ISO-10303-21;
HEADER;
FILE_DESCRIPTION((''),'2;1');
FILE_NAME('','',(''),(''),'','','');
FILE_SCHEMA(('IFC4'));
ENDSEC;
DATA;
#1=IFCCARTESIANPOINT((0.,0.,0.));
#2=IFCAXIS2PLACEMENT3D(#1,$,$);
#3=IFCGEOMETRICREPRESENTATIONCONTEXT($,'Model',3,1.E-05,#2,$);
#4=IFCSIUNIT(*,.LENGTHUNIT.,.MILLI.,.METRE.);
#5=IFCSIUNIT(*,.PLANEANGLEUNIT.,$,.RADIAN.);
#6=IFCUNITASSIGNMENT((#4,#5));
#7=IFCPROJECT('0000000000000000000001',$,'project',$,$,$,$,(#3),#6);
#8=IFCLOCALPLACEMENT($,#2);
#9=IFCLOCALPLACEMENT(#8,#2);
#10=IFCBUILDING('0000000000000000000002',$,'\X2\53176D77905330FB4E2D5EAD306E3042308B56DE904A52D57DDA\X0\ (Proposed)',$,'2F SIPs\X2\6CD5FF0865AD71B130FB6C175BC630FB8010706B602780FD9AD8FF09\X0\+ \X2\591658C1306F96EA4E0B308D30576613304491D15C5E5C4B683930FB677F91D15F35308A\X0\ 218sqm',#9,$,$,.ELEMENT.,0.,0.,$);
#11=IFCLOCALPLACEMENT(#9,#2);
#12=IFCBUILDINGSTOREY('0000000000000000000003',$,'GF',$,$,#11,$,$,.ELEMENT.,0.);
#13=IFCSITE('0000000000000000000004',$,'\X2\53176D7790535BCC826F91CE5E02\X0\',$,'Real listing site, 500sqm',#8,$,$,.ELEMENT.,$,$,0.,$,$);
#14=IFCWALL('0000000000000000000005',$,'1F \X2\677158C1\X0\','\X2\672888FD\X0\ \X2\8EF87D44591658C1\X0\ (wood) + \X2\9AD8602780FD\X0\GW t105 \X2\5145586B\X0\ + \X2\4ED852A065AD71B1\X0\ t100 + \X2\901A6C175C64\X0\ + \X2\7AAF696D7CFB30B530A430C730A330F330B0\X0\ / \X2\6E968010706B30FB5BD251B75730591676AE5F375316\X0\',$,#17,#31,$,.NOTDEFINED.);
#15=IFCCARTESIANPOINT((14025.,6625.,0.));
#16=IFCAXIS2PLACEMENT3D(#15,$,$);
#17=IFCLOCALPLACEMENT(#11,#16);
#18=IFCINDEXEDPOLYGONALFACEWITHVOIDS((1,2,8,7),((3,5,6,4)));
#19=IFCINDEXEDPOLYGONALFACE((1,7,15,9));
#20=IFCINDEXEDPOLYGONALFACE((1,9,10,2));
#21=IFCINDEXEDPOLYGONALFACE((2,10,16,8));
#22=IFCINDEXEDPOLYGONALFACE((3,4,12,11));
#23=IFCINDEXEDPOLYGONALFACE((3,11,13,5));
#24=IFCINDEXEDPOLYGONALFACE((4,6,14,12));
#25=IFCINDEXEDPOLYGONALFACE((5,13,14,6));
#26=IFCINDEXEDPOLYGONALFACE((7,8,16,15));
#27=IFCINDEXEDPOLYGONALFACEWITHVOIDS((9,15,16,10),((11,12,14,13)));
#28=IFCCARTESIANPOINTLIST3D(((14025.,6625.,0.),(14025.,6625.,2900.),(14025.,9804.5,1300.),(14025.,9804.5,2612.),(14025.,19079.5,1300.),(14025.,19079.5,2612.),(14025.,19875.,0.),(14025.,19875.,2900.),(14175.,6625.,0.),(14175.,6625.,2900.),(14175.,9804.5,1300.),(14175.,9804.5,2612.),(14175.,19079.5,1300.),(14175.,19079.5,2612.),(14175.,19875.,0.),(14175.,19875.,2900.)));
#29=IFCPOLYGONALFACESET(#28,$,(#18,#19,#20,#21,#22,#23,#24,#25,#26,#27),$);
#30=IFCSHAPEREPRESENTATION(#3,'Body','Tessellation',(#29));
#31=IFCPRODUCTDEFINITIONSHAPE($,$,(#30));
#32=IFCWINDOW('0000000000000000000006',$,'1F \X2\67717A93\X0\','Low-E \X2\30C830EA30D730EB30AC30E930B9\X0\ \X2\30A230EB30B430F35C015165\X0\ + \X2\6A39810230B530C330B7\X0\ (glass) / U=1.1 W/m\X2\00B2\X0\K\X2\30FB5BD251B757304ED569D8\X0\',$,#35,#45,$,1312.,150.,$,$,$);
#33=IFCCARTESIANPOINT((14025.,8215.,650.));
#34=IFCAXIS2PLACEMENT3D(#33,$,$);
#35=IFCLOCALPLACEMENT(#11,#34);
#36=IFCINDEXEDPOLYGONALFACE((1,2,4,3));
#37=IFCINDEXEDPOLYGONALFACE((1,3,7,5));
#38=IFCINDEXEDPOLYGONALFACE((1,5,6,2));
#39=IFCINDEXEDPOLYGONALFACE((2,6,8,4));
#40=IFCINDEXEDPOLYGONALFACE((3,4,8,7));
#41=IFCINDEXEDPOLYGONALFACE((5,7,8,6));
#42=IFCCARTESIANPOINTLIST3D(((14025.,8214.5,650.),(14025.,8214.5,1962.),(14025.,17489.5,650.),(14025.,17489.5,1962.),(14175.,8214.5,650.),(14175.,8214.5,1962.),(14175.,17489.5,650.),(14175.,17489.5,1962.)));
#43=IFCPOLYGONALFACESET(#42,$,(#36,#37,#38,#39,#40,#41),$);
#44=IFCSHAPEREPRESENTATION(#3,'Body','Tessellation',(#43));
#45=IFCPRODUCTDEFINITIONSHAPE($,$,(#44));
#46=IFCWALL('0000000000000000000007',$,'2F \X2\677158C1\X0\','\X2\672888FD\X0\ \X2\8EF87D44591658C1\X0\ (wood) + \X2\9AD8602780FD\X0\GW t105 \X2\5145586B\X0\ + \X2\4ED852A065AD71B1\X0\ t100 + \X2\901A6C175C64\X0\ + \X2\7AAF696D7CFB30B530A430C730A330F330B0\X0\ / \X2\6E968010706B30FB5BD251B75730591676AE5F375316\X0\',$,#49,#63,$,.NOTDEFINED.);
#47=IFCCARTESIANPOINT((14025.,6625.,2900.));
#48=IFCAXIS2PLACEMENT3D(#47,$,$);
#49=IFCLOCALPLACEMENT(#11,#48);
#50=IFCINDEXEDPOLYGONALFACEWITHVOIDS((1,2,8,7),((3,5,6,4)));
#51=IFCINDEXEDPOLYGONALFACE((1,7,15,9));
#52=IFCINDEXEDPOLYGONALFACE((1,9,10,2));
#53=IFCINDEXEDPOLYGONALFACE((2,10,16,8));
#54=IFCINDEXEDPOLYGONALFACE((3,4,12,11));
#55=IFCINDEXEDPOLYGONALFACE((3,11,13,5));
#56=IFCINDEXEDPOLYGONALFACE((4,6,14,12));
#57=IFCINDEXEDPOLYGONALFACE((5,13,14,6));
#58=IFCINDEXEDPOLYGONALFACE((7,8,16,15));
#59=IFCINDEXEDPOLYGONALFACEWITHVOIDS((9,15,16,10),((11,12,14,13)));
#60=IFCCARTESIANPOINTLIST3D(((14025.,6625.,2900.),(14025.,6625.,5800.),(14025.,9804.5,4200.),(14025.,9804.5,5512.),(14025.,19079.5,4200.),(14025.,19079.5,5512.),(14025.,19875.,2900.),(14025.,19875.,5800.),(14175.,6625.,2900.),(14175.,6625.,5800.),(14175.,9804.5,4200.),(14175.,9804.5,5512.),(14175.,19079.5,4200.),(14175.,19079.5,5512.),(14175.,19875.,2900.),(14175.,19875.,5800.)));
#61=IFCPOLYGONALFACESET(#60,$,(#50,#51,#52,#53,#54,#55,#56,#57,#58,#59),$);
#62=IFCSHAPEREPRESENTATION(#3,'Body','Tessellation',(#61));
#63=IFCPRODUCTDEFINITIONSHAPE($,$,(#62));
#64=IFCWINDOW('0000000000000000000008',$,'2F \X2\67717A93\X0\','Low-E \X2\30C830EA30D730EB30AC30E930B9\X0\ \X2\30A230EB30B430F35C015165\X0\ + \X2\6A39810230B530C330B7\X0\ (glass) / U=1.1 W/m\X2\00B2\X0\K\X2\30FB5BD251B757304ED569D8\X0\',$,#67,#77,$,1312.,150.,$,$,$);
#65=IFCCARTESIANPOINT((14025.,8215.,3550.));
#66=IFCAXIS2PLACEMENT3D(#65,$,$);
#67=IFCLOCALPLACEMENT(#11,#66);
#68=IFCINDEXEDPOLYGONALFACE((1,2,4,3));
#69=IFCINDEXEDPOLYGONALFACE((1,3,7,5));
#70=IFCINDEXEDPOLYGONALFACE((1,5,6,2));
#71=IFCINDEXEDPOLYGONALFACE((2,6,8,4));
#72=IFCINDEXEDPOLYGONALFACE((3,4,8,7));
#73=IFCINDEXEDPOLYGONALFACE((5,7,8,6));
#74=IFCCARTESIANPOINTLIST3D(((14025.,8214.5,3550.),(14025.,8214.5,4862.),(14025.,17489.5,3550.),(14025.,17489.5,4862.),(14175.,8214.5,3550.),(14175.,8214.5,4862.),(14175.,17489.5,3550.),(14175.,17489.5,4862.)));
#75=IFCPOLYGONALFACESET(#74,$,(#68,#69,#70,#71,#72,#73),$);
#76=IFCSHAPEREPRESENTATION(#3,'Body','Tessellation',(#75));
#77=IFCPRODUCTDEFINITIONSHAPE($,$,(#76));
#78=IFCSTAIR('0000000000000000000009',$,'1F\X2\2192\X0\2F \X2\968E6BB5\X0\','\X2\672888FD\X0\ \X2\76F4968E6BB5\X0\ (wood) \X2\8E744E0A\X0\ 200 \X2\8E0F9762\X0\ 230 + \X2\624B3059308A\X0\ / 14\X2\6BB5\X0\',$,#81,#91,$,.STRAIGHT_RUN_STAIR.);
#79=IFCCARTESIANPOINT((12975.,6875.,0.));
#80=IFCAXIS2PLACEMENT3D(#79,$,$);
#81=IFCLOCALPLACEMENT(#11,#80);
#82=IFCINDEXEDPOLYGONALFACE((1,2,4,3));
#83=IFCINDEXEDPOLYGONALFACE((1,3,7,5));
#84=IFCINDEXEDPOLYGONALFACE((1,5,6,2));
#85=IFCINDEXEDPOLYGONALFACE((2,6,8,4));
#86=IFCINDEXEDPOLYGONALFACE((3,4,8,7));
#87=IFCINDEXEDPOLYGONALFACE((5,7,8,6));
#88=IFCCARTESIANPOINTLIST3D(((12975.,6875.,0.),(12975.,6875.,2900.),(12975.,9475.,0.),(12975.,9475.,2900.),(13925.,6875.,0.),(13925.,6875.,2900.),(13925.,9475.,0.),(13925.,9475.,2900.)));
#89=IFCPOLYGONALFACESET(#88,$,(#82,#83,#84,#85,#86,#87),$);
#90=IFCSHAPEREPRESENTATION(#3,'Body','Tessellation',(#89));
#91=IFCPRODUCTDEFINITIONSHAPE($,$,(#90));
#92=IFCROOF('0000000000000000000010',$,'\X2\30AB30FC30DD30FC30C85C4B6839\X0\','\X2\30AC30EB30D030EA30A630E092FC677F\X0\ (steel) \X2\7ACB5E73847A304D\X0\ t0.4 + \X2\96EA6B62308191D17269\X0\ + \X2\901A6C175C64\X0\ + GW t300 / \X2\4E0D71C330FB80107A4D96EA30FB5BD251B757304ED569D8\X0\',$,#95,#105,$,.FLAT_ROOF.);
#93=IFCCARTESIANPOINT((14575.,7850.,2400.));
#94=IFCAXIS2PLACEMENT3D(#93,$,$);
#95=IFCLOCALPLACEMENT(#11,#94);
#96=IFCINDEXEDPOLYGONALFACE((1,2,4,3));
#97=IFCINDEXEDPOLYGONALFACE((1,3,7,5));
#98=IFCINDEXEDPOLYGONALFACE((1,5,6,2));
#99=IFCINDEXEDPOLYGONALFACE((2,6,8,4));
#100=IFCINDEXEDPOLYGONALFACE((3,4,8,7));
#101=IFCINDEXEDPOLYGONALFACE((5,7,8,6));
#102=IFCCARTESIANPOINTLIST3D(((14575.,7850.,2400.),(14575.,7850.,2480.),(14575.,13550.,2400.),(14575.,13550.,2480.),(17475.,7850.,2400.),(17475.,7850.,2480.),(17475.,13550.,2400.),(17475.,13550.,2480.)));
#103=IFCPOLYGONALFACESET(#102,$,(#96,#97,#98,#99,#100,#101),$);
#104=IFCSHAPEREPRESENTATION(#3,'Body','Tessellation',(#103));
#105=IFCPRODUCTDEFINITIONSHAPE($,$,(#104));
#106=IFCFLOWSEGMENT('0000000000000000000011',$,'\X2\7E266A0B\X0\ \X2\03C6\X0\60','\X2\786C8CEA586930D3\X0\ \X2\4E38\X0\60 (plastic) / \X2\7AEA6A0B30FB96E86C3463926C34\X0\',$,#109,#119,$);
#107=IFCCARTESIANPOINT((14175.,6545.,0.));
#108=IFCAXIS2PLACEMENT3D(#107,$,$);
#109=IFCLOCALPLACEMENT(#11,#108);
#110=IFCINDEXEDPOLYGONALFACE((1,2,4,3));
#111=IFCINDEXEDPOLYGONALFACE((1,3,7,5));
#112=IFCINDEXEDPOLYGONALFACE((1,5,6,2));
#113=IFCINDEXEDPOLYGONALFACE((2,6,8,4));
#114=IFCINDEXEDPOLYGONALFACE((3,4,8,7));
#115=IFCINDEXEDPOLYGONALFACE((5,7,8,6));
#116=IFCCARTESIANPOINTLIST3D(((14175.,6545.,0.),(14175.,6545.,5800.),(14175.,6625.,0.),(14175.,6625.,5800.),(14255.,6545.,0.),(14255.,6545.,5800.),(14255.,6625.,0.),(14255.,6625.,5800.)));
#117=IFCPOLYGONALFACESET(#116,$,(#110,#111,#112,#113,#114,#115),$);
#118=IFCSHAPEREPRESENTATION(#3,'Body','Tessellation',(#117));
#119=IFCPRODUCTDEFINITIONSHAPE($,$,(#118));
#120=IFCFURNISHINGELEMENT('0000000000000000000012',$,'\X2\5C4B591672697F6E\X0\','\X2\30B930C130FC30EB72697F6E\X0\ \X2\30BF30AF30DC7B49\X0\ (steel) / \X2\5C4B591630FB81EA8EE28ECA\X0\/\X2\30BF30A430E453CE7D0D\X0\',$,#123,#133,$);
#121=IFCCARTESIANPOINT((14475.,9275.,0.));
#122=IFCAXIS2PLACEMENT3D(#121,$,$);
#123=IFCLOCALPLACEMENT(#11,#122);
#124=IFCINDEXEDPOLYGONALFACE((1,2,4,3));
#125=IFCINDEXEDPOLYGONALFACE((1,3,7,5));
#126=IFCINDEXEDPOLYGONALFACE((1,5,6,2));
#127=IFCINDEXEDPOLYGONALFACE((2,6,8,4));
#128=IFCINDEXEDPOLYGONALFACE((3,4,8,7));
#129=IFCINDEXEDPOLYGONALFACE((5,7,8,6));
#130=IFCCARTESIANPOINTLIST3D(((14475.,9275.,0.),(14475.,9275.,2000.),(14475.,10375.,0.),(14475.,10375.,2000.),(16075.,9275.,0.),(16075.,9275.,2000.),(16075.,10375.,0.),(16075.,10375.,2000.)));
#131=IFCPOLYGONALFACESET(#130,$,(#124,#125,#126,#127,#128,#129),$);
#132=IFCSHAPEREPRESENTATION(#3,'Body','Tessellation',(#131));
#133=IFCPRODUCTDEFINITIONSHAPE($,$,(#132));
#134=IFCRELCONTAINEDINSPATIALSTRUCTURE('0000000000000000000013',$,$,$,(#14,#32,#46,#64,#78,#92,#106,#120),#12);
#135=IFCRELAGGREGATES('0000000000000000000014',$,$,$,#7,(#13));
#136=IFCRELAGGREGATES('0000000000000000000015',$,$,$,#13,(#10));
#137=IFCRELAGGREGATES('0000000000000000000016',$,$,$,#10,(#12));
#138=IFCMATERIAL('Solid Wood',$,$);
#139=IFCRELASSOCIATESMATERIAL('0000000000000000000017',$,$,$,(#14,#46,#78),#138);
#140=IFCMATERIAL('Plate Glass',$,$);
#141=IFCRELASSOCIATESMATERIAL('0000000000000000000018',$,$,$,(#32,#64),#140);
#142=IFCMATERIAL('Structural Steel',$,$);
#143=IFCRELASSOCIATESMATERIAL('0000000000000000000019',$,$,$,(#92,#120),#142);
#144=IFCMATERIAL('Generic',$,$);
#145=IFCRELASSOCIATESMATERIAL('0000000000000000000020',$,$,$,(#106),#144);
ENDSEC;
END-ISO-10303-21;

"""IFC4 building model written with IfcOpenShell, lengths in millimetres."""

from ifc_helpers import new_model, si_unit, frame, frame_2d, origin, place, context, project, spatial, rectangle, extrude, material, element, fill, save


model = new_model("IFC4")

# Units and contexts
model_context = context("Model", 3, precision=1e-05, world=origin())
ifc_project = project(units=[si_unit("LENGTHUNIT", "METRE", prefix="MILLI"), si_unit("PLANEANGLEUNIT", "RADIAN")], contexts=[model_context])

# Site, building, storey
site_placement = place(None, origin())
site = spatial("IfcSite", under=ifc_project, at=site_placement, Name="北海道富良野市", ObjectType="Real listing site, 500sqm", CompositionType="ELEMENT", RefElevation=0.0)
building_placement = place(site_placement, origin())
building = spatial("IfcBuilding", under=site, at=building_placement, Name="北海道・中庭のある回遊動線 (Proposed)", ObjectType="2F SIPs法（断熱・気密・耐火性能高）+ 外壁は雪下ろし易い金属屋根・板金張り 218sqm", CompositionType="ELEMENT", ElevationOfRefHeight=0.0, ElevationOfTerrain=0.0)
storey_placement = place(building_placement, origin())
storey = spatial("IfcBuildingStorey", under=building, at=storey_placement, Name="GF", CompositionType="ELEMENT", Elevation=0.0)

# Shared definitions
ifc_material_1 = material(Name="Solid Wood")
ifc_material_2 = material(Name="Structural Steel")

# Walls, openings, windows
wall_1_placement = place(storey_placement, frame((14025.0, 6625.0, 0.0)))
wall_1 = element("IfcWall", 1, at=wall_1_placement, inside=storey, material=ifc_material_1, Name="1F 東壁", Description="木製 軸組外壁 (wood) + 高性能GW t105 充填 + 付加断熱 t100 + 通気層 + 窯業系サイディング / 準耐火・寒冷地外皮強化", PredefinedType="NOTDEFINED", context=model_context, shape_type="SweptSolid", body=[
    extrude(rectangle(XDim=150.0, YDim=13250.0, at=frame_2d((75.0, 6625.0))), frame((14025.0, 6625.0, 0.0)), (0.0, 0.0, 1.0), 2900.0),
])
opening_1_placement = place(storey_placement, frame((14025.0, 8215.0, 650.0)))
opening_1 = element("IfcOpeningElement", 2, at=opening_1_placement, cuts=wall_1, PredefinedType="NOTDEFINED", context=model_context, shape_type="SweptSolid", body=[
    extrude(rectangle(XDim=150.0, YDim=9275.0, at=frame_2d((75.0, 4637.0))), frame((14025.0, 8215.0, 650.0)), (0.0, 0.0, 1.0), 1312.0),
])
ifc_material_3 = material(Name="Plate Glass")
window_1_placement = place(storey_placement, frame((14025.0, 8215.0, 650.0)))
window_1 = element("IfcWindow", 3, at=window_1_placement, inside=storey, material=ifc_material_3, Name="1F 東窓", Description="Low-E トリプルガラス アルゴン封入 + 樹脂サッシ (glass) / U=1.1 W/m²K・寒冷地仕様", OverallHeight=1312.0, OverallWidth=150.0, context=model_context, shape_type="SweptSolid", body=[
    extrude(rectangle(XDim=150.0, YDim=9275.0, at=frame_2d((75.0, 4637.0))), frame((14025.0, 8215.0, 650.0)), (0.0, 0.0, 1.0), 1312.0),
])
fill(opening_1, window_1)
wall_2_placement = place(storey_placement, frame((14025.0, 6625.0, 2900.0)))
wall_2 = element("IfcWall", 4, at=wall_2_placement, inside=storey, material=ifc_material_1, Name="2F 東壁", Description="木製 軸組外壁 (wood) + 高性能GW t105 充填 + 付加断熱 t100 + 通気層 + 窯業系サイディング / 準耐火・寒冷地外皮強化", PredefinedType="NOTDEFINED", context=model_context, shape_type="SweptSolid", body=[
    extrude(rectangle(XDim=150.0, YDim=13250.0, at=frame_2d((75.0, 6625.0))), frame((14025.0, 6625.0, 2900.0)), (0.0, 0.0, 1.0), 2900.0),
])
opening_2_placement = place(storey_placement, frame((14025.0, 8215.0, 3550.0)))
opening_2 = element("IfcOpeningElement", 5, at=opening_2_placement, cuts=wall_2, PredefinedType="NOTDEFINED", context=model_context, shape_type="SweptSolid", body=[
    extrude(rectangle(XDim=150.0, YDim=9275.0, at=frame_2d((75.0, 4637.0))), frame((14025.0, 8215.0, 3550.0)), (0.0, 0.0, 1.0), 1312.0),
])
window_2_placement = place(storey_placement, frame((14025.0, 8215.0, 3550.0)))
window_2 = element("IfcWindow", 6, at=window_2_placement, inside=storey, material=ifc_material_3, Name="2F 東窓", Description="Low-E トリプルガラス アルゴン封入 + 樹脂サッシ (glass) / U=1.1 W/m²K・寒冷地仕様", OverallHeight=1312.0, OverallWidth=150.0, context=model_context, shape_type="SweptSolid", body=[
    extrude(rectangle(XDim=150.0, YDim=9275.0, at=frame_2d((75.0, 4637.0))), frame((14025.0, 8215.0, 3550.0)), (0.0, 0.0, 1.0), 1312.0),
])
fill(opening_2, window_2)

# Stair
stair_placement = place(storey_placement, frame((12975.0, 6875.0, 0.0)))
element("IfcStair", 7, at=stair_placement, inside=storey, material=ifc_material_1, Name="1F→2F 階段", Description="木製 直階段 (wood) 蹴上 200 踏面 230 + 手すり / 14段", PredefinedType="STRAIGHT_RUN_STAIR", context=model_context, shape_type="SweptSolid", body=[
    extrude(rectangle(XDim=950.0, YDim=2600.0, at=frame_2d((475.0, 1300.0))), frame((12975.0, 6875.0, 0.0)), (0.0, 0.0, 1.0), 2900.0),
])

# Roof
roof_placement = place(storey_placement, frame((14575.0, 7850.0, 2400.0)))
element("IfcRoof", 8, at=roof_placement, inside=storey, material=ifc_material_2, Name="カーポート屋根", Description="ガルバリウム鋼板 (steel) 立平葺き t0.4 + 雪止め金物 + 通気層 + GW t300 / 不燃・耐積雪・寒冷地仕様", PredefinedType="FLAT_ROOF", context=model_context, shape_type="SweptSolid", body=[
    extrude(rectangle(XDim=2900.0, YDim=5700.0, at=frame_2d((1450.0, 2850.0))), frame((14575.0, 7850.0, 2400.0)), (0.0, 0.0, 1.0), 80.0),
])

# Flow segment
ifc_material_4 = material(Name="Generic")
flow_segment_placement = place(storey_placement, frame((14175.0, 6545.0, 0.0)))
element("IfcFlowSegment", 9, at=flow_segment_placement, inside=storey, material=ifc_material_4, Name="縦樋 φ60", Description="硬質塩ビ 丸60 (plastic) / 竪樋・雨水排水", context=model_context, shape_type="SweptSolid", body=[
    extrude(rectangle(XDim=80.0, YDim=80.0, at=frame_2d((40.0, 40.0))), frame((14175.0, 6545.0, 0.0)), (0.0, 0.0, 1.0), 5800.0),
])

# Furnishing element
furnishing_placement = place(storey_placement, frame((14475.0, 9275.0, 0.0)))
element("IfcFurnishingElement", 10, at=furnishing_placement, inside=storey, material=ifc_material_2, Name="屋外物置", Description="スチール物置 タクボ等 (steel) / 屋外・自転車/タイヤ収納", context=model_context, shape_type="SweptSolid", body=[
    extrude(rectangle(XDim=1600.0, YDim=1100.0, at=frame_2d((800.0, 550.0))), frame((14475.0, 9275.0, 0.0)), (0.0, 0.0, 1.0), 2000.0),
])

save(model, "model.ifc")
